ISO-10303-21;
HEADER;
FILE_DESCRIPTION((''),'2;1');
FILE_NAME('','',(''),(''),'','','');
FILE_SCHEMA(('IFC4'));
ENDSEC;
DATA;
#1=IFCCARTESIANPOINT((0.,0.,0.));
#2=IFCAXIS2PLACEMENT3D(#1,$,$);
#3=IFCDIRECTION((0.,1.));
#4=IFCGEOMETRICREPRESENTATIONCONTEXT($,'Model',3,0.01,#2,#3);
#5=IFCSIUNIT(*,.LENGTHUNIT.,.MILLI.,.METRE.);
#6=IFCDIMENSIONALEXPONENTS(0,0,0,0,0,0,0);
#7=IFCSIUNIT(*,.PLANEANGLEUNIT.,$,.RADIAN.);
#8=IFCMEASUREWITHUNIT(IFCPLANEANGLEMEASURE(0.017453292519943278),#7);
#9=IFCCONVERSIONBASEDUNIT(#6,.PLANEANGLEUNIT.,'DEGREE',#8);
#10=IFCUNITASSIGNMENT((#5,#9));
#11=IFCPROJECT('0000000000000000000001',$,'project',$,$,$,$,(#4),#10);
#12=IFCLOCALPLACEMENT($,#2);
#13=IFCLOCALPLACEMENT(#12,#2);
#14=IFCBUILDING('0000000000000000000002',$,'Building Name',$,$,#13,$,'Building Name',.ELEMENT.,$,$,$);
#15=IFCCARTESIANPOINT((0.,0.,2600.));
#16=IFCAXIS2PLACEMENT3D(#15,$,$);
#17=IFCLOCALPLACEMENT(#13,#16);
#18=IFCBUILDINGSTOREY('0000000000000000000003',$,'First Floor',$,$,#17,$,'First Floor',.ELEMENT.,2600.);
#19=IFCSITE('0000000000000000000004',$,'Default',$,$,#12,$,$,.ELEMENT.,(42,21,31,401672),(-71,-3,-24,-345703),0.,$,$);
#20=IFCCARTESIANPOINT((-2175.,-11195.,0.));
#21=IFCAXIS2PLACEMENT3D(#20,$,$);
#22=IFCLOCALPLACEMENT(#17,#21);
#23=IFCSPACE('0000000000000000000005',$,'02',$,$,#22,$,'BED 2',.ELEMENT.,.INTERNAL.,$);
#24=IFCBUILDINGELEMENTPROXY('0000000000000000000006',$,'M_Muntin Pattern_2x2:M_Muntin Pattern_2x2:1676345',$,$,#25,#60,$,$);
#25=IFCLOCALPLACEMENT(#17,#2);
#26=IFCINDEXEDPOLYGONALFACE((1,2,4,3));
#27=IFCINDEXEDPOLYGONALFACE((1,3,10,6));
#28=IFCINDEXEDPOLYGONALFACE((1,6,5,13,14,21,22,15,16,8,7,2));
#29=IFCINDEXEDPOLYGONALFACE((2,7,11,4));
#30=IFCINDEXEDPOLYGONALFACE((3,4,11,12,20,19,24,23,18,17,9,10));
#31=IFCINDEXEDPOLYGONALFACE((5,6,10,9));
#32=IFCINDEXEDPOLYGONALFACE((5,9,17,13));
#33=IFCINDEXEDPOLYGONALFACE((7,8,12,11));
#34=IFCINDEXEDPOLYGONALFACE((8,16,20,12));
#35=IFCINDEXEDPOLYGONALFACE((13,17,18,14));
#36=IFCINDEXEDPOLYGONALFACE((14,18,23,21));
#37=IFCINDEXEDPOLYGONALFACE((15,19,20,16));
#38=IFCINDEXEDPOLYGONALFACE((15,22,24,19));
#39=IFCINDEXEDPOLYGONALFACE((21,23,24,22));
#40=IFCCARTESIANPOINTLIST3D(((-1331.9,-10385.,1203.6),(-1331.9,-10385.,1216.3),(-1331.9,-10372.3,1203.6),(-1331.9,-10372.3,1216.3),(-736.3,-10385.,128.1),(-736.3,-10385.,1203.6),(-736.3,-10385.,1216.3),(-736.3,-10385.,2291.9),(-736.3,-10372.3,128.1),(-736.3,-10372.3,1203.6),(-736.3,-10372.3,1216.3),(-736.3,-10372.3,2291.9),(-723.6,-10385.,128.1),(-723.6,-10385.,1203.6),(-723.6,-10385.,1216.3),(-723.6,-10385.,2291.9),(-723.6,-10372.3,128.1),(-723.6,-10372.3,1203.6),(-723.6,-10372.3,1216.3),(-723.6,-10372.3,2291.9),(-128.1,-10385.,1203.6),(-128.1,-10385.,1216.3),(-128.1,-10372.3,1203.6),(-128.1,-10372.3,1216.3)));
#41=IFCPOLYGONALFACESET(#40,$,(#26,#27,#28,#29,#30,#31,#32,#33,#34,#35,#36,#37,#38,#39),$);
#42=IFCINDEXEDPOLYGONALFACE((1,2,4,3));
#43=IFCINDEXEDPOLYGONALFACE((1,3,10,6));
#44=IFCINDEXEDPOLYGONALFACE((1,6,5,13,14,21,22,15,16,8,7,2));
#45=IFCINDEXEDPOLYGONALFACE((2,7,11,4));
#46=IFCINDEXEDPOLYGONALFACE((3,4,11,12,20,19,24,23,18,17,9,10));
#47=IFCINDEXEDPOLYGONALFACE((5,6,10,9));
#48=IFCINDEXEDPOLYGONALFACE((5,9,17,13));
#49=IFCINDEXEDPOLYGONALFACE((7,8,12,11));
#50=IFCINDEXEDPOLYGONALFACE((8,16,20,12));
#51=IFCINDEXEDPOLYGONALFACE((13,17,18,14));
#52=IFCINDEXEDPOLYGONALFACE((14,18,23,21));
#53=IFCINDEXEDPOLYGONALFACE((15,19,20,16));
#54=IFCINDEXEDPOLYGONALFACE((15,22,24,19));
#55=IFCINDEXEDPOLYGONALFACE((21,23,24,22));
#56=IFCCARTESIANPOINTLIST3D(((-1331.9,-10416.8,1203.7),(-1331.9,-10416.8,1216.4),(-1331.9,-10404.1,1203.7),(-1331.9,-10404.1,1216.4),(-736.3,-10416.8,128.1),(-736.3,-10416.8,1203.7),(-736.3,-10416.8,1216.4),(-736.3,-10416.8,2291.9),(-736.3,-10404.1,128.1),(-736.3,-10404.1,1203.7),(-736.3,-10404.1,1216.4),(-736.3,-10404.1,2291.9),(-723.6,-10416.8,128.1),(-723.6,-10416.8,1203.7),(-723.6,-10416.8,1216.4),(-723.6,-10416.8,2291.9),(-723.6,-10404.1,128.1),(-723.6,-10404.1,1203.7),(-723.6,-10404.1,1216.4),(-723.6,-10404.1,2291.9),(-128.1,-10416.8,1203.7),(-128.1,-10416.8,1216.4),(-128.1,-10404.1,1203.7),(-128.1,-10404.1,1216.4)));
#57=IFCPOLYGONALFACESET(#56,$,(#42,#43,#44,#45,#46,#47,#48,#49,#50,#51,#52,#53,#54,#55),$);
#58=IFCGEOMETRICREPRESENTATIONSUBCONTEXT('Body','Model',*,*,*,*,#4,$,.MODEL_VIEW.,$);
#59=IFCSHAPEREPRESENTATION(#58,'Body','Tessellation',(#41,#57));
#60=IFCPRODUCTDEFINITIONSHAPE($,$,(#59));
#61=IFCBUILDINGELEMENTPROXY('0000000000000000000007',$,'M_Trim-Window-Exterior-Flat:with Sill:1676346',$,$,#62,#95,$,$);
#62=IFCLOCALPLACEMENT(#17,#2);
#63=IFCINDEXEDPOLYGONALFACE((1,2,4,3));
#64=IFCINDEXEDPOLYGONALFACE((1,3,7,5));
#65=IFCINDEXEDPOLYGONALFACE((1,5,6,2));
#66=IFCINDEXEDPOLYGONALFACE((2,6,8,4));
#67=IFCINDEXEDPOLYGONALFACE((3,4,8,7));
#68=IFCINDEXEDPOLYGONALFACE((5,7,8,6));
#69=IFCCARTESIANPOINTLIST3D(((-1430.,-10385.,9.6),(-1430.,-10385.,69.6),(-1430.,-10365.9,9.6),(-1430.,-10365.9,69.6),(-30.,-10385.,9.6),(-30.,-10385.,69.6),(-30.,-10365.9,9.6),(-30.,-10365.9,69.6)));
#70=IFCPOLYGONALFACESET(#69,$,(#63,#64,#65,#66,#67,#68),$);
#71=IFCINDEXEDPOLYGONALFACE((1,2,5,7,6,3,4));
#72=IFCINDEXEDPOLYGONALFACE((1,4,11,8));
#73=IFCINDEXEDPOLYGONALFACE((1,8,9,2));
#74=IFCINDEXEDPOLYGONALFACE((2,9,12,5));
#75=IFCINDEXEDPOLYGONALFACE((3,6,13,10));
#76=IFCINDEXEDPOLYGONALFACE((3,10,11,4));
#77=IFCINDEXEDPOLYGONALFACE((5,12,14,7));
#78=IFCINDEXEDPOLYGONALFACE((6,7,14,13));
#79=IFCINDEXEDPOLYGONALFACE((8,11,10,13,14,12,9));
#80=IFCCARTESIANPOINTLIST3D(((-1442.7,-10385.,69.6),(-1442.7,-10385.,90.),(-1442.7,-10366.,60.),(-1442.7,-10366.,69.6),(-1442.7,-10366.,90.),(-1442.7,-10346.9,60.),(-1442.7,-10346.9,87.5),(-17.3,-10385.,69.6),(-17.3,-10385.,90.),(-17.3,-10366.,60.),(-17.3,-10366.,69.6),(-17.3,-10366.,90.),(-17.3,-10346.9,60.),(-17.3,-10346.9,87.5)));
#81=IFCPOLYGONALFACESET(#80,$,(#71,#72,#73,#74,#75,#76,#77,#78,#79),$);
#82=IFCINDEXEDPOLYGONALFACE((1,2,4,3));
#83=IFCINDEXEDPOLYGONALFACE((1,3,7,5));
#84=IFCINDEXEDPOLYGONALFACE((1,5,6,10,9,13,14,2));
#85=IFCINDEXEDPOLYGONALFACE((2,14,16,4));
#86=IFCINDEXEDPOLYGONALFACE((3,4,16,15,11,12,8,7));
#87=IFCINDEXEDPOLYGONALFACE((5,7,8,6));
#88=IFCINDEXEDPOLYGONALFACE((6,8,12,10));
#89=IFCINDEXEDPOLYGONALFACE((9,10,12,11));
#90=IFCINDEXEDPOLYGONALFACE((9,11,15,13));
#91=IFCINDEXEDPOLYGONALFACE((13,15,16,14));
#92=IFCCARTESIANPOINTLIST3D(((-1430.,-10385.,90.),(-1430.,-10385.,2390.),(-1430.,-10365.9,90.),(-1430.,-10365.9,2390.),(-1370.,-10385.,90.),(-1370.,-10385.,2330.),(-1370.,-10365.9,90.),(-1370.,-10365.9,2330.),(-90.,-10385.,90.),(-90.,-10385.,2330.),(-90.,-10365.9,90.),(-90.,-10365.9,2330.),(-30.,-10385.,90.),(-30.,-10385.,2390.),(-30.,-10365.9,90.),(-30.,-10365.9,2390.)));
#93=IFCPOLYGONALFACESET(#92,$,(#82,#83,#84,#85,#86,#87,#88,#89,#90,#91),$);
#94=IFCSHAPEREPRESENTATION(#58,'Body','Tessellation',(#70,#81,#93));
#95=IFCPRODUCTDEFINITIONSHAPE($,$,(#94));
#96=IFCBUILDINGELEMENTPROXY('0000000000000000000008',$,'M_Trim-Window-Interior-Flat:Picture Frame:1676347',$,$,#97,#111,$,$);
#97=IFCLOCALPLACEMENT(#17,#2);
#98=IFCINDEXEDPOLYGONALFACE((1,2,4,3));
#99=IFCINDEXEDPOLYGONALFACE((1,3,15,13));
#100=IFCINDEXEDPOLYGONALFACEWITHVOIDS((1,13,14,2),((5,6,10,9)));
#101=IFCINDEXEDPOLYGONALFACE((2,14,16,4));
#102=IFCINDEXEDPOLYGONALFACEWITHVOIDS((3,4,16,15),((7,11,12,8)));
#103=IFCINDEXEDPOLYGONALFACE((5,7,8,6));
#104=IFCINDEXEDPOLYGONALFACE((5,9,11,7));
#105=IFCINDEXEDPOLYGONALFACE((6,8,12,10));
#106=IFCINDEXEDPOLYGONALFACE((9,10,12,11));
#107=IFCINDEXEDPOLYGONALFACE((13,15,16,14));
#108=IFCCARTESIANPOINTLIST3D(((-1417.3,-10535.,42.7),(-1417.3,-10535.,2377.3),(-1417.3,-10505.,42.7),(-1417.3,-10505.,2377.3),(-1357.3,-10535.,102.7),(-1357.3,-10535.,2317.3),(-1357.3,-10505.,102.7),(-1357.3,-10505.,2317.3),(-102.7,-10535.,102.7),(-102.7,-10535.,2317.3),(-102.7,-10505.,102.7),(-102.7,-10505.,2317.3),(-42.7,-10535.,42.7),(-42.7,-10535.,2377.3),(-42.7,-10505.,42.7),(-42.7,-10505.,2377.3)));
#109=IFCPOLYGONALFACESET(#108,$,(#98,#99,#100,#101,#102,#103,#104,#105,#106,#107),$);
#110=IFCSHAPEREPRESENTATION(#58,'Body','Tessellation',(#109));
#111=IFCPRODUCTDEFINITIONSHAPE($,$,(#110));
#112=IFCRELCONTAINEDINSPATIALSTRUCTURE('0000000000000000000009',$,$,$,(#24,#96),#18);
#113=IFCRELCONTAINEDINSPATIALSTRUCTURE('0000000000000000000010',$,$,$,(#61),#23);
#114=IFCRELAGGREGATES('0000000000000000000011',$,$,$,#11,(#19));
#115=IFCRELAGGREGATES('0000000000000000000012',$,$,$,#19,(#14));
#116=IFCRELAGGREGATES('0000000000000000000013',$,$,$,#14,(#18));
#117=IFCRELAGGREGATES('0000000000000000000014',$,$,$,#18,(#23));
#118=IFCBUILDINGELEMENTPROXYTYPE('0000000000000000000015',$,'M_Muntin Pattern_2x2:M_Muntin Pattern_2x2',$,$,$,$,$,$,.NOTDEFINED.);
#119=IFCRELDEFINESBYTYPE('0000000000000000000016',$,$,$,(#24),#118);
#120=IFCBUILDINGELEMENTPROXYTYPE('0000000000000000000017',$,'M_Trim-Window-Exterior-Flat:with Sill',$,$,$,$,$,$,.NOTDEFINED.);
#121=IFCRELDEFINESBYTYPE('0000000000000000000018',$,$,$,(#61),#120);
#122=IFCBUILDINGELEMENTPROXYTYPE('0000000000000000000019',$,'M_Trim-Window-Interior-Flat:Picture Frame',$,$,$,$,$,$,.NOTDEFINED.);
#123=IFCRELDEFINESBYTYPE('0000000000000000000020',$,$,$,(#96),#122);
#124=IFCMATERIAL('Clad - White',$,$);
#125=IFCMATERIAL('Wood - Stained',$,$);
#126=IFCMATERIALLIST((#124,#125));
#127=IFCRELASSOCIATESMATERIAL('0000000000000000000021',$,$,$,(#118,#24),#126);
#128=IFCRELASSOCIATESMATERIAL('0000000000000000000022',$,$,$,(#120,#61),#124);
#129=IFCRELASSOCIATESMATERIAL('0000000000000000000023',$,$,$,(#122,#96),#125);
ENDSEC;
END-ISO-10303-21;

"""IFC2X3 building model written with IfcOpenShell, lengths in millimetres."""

from ifc_helpers import new_model, entity, si_unit, converted_unit, direction, frame, frame_2d, origin, place, context, subcontext, project, spatial, polyline, rectangle, outline, extrude, source, transform, mapped, material, material_list, type_object, type_shapes, element, save


model = new_model("IFC2X3")

# Units and contexts
model_context = context("Model", 3, precision=0.01, world=origin(), true_north=direction((0.0, 1.0)))
body_context = subcontext(model_context, "Body", "Model", "MODEL_VIEW")
ifc_project = project(units=[si_unit("LENGTHUNIT", "METRE", prefix="MILLI"), converted_unit("PLANEANGLEUNIT", "DEGREE", entity("IfcPlaneAngleMeasure", 0.017453292519943278), si_unit("PLANEANGLEUNIT", "RADIAN"), dimensions=[0, 0, 0, 0, 0, 0, 0])], contexts=[model_context])

# Site, building, storey
site_placement = place(None, origin())
site = spatial("IfcSite", under=ifc_project, at=site_placement, Name="Default", CompositionType="ELEMENT", RefLatitude=(42, 21, 31, 401672), RefLongitude=(-71, -3, -24, -345703), RefElevation=0.0)
building_placement = place(site_placement, origin())
building = spatial("IfcBuilding", under=site, at=building_placement, Name="Building Name", LongName="Building Name", CompositionType="ELEMENT")
storey_placement = place(building_placement, frame((0.0, 0.0, 2600.0)))
storey = spatial("IfcBuildingStorey", under=building, at=storey_placement, Name="First Floor", LongName="First Floor", CompositionType="ELEMENT", Elevation=2600.0)

# Shared definitions
space_1_placement = place(storey_placement, frame((-2175.0, -11195.0, 0.0)))
space_1 = spatial("IfcSpace", under=storey, at=space_1_placement, Name="02", LongName="BED 2", CompositionType="ELEMENT", InteriorOrExteriorSpace="INTERNAL")

# Building element proxies
ifc_material_1 = material(Name="Clad - White")
ifc_material_2 = material(Name="Wood - Stained")
ifc_material_list_1 = material_list([ifc_material_1, ifc_material_2])
building_element_proxy_type_1 = type_object("IfcBuildingElementProxyType", Name="M_Muntin Pattern_2x2:M_Muntin Pattern_2x2", PredefinedType="NOTDEFINED", material=ifc_material_list_1)
shared_shape_1 = source(origin(), body_context, "Body", "SweptSolid", [
    extrude(outline(polyline([(6.4, -6.4), (1081.9, -6.4), (1081.9, 6.3), (6.4, 6.3), (6.4, 601.9), (-6.3, 601.9), (-6.3, 6.3), (-1081.9, 6.3), (-1081.9, -6.4), (-6.3, -6.4), (-6.3, -601.9), (6.4, -601.9), (6.4, -6.4)])), frame((0.0, -22.2, 1081.9), z_axis=(0.0, 1.0, 0.0), x_axis=(0.0, 0.0, 1.0)), (0.0, 0.0, 1.0), 12.7),
    extrude(outline(polyline([(6.4, -6.4), (1081.9, -6.4), (1081.9, 6.3), (6.4, 6.3), (6.4, 601.9), (-6.3, 601.9), (-6.3, 6.3), (-1081.9, 6.3), (-1081.9, -6.4), (-6.3, -6.4), (-6.3, -601.9), (6.4, -601.9), (6.4, -6.4)])), frame((0.0, 9.5, 1081.9), z_axis=(0.0, 1.0, 0.0), x_axis=(0.0, 0.0, 1.0)), (0.0, 0.0, 1.0), 12.7),
])
type_shapes(building_element_proxy_type_1, [shared_shape_1])
proxy_1_placement = place(storey_placement, frame((-730.0, -10394.5, 128.1), z_axis=(0.0, 0.0, 1.0), x_axis=(-1.0, 0.0, 0.0)))
element("IfcBuildingElementProxy", 1, at=proxy_1_placement, inside=storey, type_object=building_element_proxy_type_1, material=ifc_material_list_1, Name="M_Muntin Pattern_2x2:M_Muntin Pattern_2x2:1676345", context=body_context, shape_type="MappedRepresentation", body=[
    mapped(shared_shape_1, transform((0.0, 0.0, 0.0), scale=1.0)),
])
building_element_proxy_type_2 = type_object("IfcBuildingElementProxyType", Name="M_Trim-Window-Exterior-Flat:with Sill", PredefinedType="NOTDEFINED", material=ifc_material_1)
shared_shape_2 = source(origin(), body_context, "Body", "SweptSolid", [
    extrude(rectangle(XDim=1400.0, YDim=60.0, at=frame_2d((0.0, 0.0), x_axis=(1.0, 0.0))), frame((0.0, -2290.4, 0.0), z_axis=(0.0, 0.0, 1.0), x_axis=(-1.0, 0.0, 0.0)), (0.0, 0.0, 1.0), 19.0),
    extrude(outline(polyline([(-19.0, -15.2), (0.0, -15.2), (0.0, -5.7), (19.0, -5.7), (19.0, 14.8), (0.0, 14.8), (-19.0, 12.3), (-19.0, -15.2)])), frame((-712.7, -2254.8, 19.0), z_axis=(1.0, 0.0, 0.0), x_axis=(0.0, 0.0, -1.0)), (0.0, 0.0, 1.0), 1425.4),
    extrude(outline(polyline([(-1165.0, -700.0), (1135.0, -700.0), (1135.0, -640.0), (-1105.0, -640.0), (-1105.0, 640.0), (1135.0, 640.0), (1135.0, 700.0), (-1165.0, 700.0), (-1165.0, -700.0)])), frame((0.0, -1105.0, 0.0), z_axis=(0.0, 0.0, 1.0), x_axis=(0.0, -1.0, 0.0)), (0.0, 0.0, 1.0), 19.0),
])
type_shapes(building_element_proxy_type_2, [shared_shape_2])
proxy_2_placement = place(space_1_placement, frame((1445.0, 810.0, 2330.0), z_axis=(0.0, 1.0, 0.0), x_axis=(-1.0, 0.0, 0.0)))
element("IfcBuildingElementProxy", 2, at=proxy_2_placement, inside=space_1, type_object=building_element_proxy_type_2, material=ifc_material_1, Name="M_Trim-Window-Exterior-Flat:with Sill:1676346", context=body_context, shape_type="MappedRepresentation", body=[
    mapped(shared_shape_2, transform((0.0, 0.0, 0.0), scale=1.0)),
])
building_element_proxy_type_3 = type_object("IfcBuildingElementProxyType", Name="M_Trim-Window-Interior-Flat:Picture Frame", PredefinedType="NOTDEFINED", material=ifc_material_2)
shared_shape_3 = source(origin(), body_context, "Body", "SweptSolid", [
    extrude(outline(polyline([(-687.3, -1167.3), (687.3, -1167.3), (687.3, 1167.3), (-687.3, 1167.3), (-687.3, -1167.3)]), holes=[polyline([(-627.3, -1107.3), (-627.3, 1107.3), (627.3, 1107.3), (627.3, -1107.3), (-627.3, -1107.3)])]), frame((0.0, -1120.0, 0.0), z_axis=(0.0, 0.0, 1.0), x_axis=(-1.0, 0.0, 0.0)), (0.0, 0.0, 1.0), 30.0),
])
type_shapes(building_element_proxy_type_3, [shared_shape_3])
proxy_3_placement = place(storey_placement, frame((-730.0, -10505.0, 2330.0), z_axis=(0.0, -1.0, 0.0), x_axis=(1.0, 0.0, 0.0)))
element("IfcBuildingElementProxy", 3, at=proxy_3_placement, inside=storey, type_object=building_element_proxy_type_3, material=ifc_material_2, Name="M_Trim-Window-Interior-Flat:Picture Frame:1676347", context=body_context, shape_type="MappedRepresentation", body=[
    mapped(shared_shape_3, transform((0.0, 0.0, 0.0), scale=1.0)),
])

save(model, "model.ifc")
